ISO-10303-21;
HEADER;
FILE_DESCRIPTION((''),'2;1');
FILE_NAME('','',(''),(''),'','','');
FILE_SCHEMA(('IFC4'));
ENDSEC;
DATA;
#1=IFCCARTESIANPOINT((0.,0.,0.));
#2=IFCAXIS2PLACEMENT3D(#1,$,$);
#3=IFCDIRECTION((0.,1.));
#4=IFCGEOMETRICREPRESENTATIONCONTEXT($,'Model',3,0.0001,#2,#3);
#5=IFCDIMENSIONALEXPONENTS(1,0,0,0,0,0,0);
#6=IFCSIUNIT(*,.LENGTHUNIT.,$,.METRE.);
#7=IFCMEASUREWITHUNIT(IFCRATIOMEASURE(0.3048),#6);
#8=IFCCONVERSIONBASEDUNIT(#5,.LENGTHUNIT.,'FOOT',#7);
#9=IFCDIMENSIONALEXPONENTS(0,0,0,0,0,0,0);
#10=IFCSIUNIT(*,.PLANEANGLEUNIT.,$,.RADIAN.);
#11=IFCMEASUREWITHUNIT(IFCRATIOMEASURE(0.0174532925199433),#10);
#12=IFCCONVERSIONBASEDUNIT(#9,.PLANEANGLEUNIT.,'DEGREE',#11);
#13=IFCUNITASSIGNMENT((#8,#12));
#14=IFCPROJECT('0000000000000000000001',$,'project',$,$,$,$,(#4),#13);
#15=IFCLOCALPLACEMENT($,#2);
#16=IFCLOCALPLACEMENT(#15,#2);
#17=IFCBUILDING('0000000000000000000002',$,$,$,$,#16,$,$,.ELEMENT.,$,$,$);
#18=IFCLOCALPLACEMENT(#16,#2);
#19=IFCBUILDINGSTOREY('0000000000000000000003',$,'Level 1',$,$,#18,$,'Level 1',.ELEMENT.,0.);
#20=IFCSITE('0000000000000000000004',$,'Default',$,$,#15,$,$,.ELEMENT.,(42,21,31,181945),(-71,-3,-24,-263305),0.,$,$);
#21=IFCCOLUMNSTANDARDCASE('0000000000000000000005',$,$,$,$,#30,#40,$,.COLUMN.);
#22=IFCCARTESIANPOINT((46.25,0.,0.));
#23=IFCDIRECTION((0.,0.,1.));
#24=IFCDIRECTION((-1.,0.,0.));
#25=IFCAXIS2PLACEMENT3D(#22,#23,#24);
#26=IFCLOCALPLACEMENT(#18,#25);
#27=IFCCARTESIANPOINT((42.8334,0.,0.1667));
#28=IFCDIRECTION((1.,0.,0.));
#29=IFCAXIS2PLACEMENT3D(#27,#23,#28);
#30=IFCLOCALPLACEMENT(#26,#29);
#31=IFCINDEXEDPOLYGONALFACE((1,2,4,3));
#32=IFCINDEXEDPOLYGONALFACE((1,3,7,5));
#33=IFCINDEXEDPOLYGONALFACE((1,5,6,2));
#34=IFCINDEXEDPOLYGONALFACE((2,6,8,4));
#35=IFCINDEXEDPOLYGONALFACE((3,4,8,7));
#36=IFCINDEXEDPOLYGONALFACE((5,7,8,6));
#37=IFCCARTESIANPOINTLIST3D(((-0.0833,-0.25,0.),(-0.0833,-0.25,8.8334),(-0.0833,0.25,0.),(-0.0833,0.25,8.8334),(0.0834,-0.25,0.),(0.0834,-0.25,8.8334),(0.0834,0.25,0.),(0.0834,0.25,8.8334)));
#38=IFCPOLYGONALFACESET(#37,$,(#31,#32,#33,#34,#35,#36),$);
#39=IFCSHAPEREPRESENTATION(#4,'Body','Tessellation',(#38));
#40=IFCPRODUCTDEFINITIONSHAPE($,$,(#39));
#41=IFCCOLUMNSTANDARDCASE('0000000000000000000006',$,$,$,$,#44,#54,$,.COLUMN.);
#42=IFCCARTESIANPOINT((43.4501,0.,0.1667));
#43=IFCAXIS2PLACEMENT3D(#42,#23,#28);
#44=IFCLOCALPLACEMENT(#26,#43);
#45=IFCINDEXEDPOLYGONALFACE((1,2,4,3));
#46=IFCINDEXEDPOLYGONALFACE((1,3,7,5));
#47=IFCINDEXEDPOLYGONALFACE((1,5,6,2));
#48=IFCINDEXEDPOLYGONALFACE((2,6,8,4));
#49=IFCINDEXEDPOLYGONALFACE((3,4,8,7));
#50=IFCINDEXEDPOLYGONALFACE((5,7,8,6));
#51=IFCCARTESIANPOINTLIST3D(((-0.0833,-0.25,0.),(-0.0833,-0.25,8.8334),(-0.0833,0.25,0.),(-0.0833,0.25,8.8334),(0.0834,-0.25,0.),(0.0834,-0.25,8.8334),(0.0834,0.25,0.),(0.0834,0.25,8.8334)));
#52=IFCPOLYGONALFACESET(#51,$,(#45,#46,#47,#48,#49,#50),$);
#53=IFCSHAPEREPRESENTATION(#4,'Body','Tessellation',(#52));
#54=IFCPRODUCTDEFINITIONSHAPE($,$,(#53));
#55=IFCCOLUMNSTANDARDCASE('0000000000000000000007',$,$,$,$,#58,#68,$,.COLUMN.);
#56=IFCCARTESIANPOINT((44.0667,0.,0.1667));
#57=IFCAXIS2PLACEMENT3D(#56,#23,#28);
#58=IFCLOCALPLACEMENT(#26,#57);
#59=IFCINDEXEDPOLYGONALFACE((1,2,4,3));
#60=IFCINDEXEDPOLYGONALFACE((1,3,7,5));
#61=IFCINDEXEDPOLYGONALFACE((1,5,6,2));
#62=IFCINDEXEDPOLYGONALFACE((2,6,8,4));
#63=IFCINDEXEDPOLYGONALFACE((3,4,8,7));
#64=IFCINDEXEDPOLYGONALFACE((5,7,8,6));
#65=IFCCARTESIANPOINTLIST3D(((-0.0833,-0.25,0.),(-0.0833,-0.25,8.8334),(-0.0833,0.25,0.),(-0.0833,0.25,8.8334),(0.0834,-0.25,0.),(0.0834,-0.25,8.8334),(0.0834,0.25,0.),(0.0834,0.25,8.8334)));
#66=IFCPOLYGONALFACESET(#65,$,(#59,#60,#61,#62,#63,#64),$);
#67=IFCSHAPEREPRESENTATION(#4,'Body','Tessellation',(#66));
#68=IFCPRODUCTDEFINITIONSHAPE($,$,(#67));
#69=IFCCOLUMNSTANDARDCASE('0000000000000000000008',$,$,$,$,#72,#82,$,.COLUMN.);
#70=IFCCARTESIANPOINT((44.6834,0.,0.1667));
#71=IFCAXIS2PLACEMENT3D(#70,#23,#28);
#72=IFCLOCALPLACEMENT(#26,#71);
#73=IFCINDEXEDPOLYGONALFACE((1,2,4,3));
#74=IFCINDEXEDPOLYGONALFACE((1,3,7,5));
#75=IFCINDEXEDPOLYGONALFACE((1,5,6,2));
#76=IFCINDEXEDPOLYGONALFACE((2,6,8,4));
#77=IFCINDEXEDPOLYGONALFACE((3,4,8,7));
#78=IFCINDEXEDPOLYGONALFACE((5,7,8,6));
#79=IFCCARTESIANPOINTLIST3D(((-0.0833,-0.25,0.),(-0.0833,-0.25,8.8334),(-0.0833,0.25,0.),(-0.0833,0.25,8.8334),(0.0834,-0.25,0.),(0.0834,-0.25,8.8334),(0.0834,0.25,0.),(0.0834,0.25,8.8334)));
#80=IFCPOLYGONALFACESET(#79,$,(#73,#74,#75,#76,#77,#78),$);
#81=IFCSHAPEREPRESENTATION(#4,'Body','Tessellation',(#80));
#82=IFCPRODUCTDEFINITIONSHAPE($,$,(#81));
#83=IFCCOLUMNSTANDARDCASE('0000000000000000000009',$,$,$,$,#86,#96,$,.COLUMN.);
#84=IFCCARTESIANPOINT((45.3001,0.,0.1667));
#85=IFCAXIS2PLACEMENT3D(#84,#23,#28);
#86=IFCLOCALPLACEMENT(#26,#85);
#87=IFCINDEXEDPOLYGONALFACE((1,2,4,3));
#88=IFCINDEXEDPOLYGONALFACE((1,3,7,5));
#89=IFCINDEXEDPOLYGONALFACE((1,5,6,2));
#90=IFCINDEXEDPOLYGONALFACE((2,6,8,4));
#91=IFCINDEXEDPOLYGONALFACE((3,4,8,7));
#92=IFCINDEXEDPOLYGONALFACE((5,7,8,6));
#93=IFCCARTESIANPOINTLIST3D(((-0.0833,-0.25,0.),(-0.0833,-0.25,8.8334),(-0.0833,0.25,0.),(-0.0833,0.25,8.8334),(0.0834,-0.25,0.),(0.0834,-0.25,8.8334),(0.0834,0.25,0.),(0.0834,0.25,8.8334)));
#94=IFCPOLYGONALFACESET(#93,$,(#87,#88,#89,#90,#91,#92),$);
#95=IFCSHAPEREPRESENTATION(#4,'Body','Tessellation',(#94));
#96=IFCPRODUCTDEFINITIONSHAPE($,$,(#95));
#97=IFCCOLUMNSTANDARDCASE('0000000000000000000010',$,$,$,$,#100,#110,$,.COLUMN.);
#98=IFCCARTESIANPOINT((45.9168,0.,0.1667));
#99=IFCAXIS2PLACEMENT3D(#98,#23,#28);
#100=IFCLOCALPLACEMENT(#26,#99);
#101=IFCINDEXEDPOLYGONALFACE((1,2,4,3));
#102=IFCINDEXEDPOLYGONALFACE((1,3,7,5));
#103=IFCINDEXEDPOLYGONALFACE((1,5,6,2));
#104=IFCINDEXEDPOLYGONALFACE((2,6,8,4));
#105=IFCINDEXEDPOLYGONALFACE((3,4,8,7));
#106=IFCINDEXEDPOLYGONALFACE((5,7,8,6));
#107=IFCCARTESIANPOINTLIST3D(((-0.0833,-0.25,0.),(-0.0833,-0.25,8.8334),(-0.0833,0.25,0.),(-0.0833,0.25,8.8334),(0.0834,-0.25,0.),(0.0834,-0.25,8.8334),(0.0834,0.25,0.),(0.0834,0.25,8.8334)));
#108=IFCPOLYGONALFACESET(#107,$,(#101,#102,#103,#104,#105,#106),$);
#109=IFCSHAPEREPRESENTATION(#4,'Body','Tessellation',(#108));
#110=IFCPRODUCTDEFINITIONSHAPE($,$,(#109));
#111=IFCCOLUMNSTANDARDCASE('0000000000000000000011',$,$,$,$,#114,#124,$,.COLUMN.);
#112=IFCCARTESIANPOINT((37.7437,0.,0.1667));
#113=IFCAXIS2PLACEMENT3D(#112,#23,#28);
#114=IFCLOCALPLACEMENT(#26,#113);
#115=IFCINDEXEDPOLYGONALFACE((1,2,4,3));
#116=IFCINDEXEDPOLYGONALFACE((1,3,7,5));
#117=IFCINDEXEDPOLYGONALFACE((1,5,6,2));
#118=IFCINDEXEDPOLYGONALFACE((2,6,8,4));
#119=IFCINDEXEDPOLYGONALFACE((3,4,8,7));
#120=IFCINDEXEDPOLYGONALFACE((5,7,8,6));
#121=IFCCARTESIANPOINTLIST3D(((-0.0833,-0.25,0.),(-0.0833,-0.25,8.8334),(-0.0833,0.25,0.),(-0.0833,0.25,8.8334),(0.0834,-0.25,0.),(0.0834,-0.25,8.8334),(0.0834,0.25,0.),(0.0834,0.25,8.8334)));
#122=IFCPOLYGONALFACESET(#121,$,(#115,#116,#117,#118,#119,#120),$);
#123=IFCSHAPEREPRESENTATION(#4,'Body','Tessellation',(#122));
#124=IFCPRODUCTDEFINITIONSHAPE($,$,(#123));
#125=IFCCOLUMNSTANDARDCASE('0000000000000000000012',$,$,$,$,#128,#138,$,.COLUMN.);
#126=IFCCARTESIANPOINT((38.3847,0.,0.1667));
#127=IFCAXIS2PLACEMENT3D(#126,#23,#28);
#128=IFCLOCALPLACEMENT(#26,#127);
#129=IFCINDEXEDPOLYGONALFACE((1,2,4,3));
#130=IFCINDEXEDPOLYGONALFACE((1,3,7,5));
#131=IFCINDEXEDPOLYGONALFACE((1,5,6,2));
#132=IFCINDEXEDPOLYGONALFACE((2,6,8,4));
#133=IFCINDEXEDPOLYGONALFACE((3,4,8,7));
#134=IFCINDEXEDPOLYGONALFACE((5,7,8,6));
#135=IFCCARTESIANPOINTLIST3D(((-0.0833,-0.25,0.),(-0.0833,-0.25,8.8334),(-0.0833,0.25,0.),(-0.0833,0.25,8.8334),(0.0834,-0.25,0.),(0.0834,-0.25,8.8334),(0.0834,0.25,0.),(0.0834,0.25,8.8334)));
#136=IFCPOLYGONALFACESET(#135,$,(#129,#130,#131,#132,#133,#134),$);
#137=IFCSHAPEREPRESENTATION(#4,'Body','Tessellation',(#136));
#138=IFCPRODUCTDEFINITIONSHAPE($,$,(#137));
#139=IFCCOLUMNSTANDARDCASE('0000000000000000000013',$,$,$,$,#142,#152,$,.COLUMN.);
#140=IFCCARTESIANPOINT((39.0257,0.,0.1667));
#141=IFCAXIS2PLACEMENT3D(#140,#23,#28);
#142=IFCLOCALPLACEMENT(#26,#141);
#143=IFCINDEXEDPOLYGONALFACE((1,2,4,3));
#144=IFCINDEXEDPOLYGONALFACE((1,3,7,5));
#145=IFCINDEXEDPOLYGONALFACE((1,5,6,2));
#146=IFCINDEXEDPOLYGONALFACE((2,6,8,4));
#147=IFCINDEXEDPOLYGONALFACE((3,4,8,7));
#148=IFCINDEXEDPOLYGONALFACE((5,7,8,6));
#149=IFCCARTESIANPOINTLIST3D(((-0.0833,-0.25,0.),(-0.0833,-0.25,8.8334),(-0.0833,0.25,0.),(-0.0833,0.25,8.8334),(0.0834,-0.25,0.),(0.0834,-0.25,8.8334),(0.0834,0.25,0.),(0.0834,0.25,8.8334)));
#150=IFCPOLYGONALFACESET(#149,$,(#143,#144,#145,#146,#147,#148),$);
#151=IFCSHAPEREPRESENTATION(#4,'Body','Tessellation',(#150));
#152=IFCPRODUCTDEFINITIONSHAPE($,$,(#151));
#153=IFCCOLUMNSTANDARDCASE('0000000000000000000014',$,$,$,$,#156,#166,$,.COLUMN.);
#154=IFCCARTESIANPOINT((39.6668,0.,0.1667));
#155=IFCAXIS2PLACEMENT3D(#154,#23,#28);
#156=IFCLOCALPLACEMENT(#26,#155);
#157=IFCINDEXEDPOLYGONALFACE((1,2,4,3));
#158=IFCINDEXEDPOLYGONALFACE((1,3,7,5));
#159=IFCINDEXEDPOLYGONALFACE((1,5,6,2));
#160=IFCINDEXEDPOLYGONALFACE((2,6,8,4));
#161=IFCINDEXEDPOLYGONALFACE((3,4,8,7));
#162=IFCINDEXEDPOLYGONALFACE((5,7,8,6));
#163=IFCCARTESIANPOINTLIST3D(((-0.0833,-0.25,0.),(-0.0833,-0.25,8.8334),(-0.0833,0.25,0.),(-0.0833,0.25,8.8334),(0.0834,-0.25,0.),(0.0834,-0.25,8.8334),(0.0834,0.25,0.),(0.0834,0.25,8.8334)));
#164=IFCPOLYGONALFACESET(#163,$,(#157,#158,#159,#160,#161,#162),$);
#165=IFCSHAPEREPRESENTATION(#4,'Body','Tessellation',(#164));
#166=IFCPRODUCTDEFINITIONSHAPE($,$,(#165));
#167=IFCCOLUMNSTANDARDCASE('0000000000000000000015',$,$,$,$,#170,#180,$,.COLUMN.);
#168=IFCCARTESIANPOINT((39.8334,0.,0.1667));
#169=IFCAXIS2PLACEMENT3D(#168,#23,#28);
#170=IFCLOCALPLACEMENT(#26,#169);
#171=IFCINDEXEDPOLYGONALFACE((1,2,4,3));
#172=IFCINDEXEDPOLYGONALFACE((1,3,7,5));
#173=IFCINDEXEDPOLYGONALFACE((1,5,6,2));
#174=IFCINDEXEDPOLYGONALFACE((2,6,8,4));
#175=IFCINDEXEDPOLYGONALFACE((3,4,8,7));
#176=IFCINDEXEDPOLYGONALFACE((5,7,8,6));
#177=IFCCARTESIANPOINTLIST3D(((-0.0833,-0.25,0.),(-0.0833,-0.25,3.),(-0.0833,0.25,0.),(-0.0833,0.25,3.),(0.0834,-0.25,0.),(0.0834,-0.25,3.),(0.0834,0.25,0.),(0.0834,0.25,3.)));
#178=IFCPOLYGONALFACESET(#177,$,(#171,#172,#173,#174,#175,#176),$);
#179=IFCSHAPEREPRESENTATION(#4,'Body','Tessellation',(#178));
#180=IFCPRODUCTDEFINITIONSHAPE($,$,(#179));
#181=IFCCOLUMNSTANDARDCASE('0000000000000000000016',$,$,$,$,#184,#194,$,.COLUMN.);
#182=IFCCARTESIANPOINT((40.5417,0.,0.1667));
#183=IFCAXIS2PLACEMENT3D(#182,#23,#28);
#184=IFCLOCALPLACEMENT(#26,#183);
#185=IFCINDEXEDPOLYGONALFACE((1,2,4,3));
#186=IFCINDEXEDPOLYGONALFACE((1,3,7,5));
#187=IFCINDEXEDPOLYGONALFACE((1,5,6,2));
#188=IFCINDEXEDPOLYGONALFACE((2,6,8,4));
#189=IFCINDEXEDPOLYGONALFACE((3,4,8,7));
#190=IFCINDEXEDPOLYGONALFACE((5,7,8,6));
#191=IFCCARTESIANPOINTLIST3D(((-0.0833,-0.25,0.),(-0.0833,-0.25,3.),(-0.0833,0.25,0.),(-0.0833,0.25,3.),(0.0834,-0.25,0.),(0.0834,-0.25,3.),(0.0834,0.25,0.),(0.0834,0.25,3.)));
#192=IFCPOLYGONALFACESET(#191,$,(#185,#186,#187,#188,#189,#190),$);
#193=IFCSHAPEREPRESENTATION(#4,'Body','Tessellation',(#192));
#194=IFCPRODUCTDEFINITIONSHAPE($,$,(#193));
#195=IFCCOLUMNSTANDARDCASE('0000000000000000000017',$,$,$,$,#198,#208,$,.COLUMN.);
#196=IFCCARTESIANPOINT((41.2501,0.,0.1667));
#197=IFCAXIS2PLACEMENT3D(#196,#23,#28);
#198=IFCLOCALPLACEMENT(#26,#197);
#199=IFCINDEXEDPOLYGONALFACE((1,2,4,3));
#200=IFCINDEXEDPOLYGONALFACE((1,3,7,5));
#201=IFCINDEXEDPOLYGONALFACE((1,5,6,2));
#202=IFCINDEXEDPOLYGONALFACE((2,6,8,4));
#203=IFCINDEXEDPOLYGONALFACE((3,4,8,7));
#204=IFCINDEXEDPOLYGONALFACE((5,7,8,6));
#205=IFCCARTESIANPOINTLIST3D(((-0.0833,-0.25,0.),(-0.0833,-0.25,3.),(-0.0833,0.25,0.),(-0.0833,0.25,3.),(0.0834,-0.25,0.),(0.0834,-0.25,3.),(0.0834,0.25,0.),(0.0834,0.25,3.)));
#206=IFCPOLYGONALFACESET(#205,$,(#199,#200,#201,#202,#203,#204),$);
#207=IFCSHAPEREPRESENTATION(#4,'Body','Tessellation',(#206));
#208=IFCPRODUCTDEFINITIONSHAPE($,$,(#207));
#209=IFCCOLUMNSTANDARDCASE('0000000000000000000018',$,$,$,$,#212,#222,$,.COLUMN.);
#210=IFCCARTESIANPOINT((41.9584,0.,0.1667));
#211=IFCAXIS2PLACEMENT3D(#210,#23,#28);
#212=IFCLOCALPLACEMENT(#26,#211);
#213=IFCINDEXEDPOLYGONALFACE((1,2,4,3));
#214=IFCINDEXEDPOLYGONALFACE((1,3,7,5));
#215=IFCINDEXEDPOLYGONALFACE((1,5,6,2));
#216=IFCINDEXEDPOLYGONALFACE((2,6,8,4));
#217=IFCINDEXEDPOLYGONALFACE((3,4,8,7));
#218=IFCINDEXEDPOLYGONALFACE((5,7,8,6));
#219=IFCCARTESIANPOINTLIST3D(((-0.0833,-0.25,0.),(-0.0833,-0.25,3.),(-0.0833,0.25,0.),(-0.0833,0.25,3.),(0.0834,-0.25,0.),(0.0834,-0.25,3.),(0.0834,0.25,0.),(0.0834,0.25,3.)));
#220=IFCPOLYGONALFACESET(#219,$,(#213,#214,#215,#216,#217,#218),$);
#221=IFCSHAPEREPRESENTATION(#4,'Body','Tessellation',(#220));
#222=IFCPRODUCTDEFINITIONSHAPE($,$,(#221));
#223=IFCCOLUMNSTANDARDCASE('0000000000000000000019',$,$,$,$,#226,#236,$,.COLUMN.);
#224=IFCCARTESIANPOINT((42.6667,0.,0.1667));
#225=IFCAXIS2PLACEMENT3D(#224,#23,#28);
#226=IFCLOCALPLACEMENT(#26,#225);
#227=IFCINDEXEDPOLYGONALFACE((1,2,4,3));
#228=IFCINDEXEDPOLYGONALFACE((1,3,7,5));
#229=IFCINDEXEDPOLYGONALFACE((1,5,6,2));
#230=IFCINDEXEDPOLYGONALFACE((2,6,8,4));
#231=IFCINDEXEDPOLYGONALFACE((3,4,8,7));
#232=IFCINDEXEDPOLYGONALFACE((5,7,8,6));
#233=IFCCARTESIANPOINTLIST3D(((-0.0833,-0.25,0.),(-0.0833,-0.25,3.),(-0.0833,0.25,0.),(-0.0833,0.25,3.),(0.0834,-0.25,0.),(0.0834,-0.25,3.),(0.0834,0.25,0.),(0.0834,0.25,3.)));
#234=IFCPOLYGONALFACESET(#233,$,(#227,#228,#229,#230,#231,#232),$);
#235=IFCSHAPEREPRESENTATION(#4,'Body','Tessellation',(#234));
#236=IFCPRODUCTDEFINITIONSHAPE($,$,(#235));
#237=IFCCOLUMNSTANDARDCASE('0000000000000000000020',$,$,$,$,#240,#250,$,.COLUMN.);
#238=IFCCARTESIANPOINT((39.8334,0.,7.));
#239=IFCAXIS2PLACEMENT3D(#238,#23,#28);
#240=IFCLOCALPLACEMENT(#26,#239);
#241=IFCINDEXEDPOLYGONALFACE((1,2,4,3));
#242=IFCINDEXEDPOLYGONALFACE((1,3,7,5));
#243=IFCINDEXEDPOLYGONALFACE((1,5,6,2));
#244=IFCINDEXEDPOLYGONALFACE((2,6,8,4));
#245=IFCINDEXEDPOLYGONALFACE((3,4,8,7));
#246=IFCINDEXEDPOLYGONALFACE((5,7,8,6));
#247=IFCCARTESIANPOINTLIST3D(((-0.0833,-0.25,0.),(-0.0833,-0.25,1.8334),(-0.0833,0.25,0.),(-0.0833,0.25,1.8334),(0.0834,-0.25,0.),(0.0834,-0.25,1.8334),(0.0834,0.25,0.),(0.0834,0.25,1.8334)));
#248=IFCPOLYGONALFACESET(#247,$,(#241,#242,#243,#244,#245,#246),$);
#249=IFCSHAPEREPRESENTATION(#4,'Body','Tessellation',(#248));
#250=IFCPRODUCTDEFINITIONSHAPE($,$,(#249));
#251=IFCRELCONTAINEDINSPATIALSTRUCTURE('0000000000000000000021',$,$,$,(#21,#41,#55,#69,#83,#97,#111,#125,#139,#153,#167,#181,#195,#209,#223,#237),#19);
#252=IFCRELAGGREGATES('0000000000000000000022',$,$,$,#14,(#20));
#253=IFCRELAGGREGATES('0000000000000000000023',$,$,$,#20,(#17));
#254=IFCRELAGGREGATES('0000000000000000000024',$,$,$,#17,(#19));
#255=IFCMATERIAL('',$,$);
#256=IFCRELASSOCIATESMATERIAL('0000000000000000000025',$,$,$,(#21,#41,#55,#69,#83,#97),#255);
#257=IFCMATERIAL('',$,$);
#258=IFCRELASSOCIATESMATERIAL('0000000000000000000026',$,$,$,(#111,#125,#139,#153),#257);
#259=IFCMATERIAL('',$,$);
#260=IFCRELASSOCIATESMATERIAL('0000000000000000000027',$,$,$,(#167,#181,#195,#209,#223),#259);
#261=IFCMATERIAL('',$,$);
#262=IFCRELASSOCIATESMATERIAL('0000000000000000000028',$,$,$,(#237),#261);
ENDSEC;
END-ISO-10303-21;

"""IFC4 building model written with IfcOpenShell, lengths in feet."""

from ifc_helpers import new_model, entity, si_unit, converted_unit, direction, frame, origin, place, context, project, spatial, rectangle, extrude, material, element, save


model = new_model("IFC4")

# Units and contexts
model_context = context("Model", 3, precision=0.0001, world=origin(), true_north=direction((0.0, 1.0)))
ifc_project = project(units=[converted_unit("LENGTHUNIT", "FOOT", entity("IfcRatioMeasure", 0.3048), si_unit("LENGTHUNIT", "METRE"), dimensions=[1, 0, 0, 0, 0, 0, 0]), converted_unit("PLANEANGLEUNIT", "DEGREE", entity("IfcRatioMeasure", 0.0174532925199433), si_unit("PLANEANGLEUNIT", "RADIAN"), dimensions=[0, 0, 0, 0, 0, 0, 0])], contexts=[model_context])

# Site, building, storey
site_placement = place(None, origin())
site = spatial("IfcSite", under=ifc_project, at=site_placement, Name="Default", CompositionType="ELEMENT", RefLatitude=(42, 21, 31, 181945), RefLongitude=(-71, -3, -24, -263305), RefElevation=0.0)
building_placement = place(site_placement, origin())
building = spatial("IfcBuilding", under=site, at=building_placement, CompositionType="ELEMENT")
storey_placement = place(building_placement, origin())
storey = spatial("IfcBuildingStorey", under=building, at=storey_placement, Name="Level 1", LongName="Level 1", CompositionType="ELEMENT", Elevation=0.0)

# Columns
ifc_material_1 = material(Name="")
placement_1 = place(storey_placement, frame((46.25, 0.0, 0.0), z_axis=(0.0, 0.0, 1.0), x_axis=(-1.0, 0.0, 0.0)))
for number, where, z_axis, x_axis in (
    (1, (42.8334, 0.0, 0.1667), (0.0, 0.0, 1.0), (1.0, 0.0, 0.0)),
    (2, (43.4501, 0.0, 0.1667), (0.0, 0.0, 1.0), (1.0, 0.0, 0.0)),
    (3, (44.0667, 0.0, 0.1667), (0.0, 0.0, 1.0), (1.0, 0.0, 0.0)),
    (4, (44.6834, 0.0, 0.1667), (0.0, 0.0, 1.0), (1.0, 0.0, 0.0)),
    (5, (45.3001, 0.0, 0.1667), (0.0, 0.0, 1.0), (1.0, 0.0, 0.0)),
    (6, (45.9168, 0.0, 0.1667), (0.0, 0.0, 1.0), (1.0, 0.0, 0.0)),
):
    element("IfcColumnStandardCase", number, at=place(placement_1, frame(where, z_axis=z_axis, x_axis=x_axis)), inside=storey, material=ifc_material_1, PredefinedType="COLUMN", context=model_context, shape_type="SweptSolid", body=[
        extrude(rectangle(XDim=0.1667, YDim=0.5), origin(), (0.0, 0.0, 1.0), 8.8334),
    ])
ifc_material_2 = material(Name="")
for number, where, z_axis, x_axis in (
    (7, (37.7437, 0.0, 0.1667), (0.0, 0.0, 1.0), (1.0, 0.0, 0.0)),
    (8, (38.3847, 0.0, 0.1667), (0.0, 0.0, 1.0), (1.0, 0.0, 0.0)),
    (9, (39.0257, 0.0, 0.1667), (0.0, 0.0, 1.0), (1.0, 0.0, 0.0)),
    (10, (39.6668, 0.0, 0.1667), (0.0, 0.0, 1.0), (1.0, 0.0, 0.0)),
):
    element("IfcColumnStandardCase", number, at=place(placement_1, frame(where, z_axis=z_axis, x_axis=x_axis)), inside=storey, material=ifc_material_2, PredefinedType="COLUMN", context=model_context, shape_type="SweptSolid", body=[
        extrude(rectangle(XDim=0.1667, YDim=0.5), origin(), (0.0, 0.0, 1.0), 8.8334),
    ])
ifc_material_3 = material(Name="")
for number, where, z_axis, x_axis in (
    (11, (39.8334, 0.0, 0.1667), (0.0, 0.0, 1.0), (1.0, 0.0, 0.0)),
    (12, (40.5417, 0.0, 0.1667), (0.0, 0.0, 1.0), (1.0, 0.0, 0.0)),
    (13, (41.2501, 0.0, 0.1667), (0.0, 0.0, 1.0), (1.0, 0.0, 0.0)),
    (14, (41.9584, 0.0, 0.1667), (0.0, 0.0, 1.0), (1.0, 0.0, 0.0)),
    (15, (42.6667, 0.0, 0.1667), (0.0, 0.0, 1.0), (1.0, 0.0, 0.0)),
):
    element("IfcColumnStandardCase", number, at=place(placement_1, frame(where, z_axis=z_axis, x_axis=x_axis)), inside=storey, material=ifc_material_3, PredefinedType="COLUMN", context=model_context, shape_type="SweptSolid", body=[
        extrude(rectangle(XDim=0.1667, YDim=0.5), origin(), (0.0, 0.0, 1.0), 3.0),
    ])
ifc_material_4 = material(Name="")
for number, where, z_axis, x_axis in (
    (16, (39.8334, 0.0, 7.0), (0.0, 0.0, 1.0), (1.0, 0.0, 0.0)),
):
    element("IfcColumnStandardCase", number, at=place(placement_1, frame(where, z_axis=z_axis, x_axis=x_axis)), inside=storey, material=ifc_material_4, PredefinedType="COLUMN", context=model_context, shape_type="SweptSolid", body=[
        extrude(rectangle(XDim=0.1667, YDim=0.5), origin(), (0.0, 0.0, 1.0), 1.8334),
    ])

save(model, "model.ifc")
